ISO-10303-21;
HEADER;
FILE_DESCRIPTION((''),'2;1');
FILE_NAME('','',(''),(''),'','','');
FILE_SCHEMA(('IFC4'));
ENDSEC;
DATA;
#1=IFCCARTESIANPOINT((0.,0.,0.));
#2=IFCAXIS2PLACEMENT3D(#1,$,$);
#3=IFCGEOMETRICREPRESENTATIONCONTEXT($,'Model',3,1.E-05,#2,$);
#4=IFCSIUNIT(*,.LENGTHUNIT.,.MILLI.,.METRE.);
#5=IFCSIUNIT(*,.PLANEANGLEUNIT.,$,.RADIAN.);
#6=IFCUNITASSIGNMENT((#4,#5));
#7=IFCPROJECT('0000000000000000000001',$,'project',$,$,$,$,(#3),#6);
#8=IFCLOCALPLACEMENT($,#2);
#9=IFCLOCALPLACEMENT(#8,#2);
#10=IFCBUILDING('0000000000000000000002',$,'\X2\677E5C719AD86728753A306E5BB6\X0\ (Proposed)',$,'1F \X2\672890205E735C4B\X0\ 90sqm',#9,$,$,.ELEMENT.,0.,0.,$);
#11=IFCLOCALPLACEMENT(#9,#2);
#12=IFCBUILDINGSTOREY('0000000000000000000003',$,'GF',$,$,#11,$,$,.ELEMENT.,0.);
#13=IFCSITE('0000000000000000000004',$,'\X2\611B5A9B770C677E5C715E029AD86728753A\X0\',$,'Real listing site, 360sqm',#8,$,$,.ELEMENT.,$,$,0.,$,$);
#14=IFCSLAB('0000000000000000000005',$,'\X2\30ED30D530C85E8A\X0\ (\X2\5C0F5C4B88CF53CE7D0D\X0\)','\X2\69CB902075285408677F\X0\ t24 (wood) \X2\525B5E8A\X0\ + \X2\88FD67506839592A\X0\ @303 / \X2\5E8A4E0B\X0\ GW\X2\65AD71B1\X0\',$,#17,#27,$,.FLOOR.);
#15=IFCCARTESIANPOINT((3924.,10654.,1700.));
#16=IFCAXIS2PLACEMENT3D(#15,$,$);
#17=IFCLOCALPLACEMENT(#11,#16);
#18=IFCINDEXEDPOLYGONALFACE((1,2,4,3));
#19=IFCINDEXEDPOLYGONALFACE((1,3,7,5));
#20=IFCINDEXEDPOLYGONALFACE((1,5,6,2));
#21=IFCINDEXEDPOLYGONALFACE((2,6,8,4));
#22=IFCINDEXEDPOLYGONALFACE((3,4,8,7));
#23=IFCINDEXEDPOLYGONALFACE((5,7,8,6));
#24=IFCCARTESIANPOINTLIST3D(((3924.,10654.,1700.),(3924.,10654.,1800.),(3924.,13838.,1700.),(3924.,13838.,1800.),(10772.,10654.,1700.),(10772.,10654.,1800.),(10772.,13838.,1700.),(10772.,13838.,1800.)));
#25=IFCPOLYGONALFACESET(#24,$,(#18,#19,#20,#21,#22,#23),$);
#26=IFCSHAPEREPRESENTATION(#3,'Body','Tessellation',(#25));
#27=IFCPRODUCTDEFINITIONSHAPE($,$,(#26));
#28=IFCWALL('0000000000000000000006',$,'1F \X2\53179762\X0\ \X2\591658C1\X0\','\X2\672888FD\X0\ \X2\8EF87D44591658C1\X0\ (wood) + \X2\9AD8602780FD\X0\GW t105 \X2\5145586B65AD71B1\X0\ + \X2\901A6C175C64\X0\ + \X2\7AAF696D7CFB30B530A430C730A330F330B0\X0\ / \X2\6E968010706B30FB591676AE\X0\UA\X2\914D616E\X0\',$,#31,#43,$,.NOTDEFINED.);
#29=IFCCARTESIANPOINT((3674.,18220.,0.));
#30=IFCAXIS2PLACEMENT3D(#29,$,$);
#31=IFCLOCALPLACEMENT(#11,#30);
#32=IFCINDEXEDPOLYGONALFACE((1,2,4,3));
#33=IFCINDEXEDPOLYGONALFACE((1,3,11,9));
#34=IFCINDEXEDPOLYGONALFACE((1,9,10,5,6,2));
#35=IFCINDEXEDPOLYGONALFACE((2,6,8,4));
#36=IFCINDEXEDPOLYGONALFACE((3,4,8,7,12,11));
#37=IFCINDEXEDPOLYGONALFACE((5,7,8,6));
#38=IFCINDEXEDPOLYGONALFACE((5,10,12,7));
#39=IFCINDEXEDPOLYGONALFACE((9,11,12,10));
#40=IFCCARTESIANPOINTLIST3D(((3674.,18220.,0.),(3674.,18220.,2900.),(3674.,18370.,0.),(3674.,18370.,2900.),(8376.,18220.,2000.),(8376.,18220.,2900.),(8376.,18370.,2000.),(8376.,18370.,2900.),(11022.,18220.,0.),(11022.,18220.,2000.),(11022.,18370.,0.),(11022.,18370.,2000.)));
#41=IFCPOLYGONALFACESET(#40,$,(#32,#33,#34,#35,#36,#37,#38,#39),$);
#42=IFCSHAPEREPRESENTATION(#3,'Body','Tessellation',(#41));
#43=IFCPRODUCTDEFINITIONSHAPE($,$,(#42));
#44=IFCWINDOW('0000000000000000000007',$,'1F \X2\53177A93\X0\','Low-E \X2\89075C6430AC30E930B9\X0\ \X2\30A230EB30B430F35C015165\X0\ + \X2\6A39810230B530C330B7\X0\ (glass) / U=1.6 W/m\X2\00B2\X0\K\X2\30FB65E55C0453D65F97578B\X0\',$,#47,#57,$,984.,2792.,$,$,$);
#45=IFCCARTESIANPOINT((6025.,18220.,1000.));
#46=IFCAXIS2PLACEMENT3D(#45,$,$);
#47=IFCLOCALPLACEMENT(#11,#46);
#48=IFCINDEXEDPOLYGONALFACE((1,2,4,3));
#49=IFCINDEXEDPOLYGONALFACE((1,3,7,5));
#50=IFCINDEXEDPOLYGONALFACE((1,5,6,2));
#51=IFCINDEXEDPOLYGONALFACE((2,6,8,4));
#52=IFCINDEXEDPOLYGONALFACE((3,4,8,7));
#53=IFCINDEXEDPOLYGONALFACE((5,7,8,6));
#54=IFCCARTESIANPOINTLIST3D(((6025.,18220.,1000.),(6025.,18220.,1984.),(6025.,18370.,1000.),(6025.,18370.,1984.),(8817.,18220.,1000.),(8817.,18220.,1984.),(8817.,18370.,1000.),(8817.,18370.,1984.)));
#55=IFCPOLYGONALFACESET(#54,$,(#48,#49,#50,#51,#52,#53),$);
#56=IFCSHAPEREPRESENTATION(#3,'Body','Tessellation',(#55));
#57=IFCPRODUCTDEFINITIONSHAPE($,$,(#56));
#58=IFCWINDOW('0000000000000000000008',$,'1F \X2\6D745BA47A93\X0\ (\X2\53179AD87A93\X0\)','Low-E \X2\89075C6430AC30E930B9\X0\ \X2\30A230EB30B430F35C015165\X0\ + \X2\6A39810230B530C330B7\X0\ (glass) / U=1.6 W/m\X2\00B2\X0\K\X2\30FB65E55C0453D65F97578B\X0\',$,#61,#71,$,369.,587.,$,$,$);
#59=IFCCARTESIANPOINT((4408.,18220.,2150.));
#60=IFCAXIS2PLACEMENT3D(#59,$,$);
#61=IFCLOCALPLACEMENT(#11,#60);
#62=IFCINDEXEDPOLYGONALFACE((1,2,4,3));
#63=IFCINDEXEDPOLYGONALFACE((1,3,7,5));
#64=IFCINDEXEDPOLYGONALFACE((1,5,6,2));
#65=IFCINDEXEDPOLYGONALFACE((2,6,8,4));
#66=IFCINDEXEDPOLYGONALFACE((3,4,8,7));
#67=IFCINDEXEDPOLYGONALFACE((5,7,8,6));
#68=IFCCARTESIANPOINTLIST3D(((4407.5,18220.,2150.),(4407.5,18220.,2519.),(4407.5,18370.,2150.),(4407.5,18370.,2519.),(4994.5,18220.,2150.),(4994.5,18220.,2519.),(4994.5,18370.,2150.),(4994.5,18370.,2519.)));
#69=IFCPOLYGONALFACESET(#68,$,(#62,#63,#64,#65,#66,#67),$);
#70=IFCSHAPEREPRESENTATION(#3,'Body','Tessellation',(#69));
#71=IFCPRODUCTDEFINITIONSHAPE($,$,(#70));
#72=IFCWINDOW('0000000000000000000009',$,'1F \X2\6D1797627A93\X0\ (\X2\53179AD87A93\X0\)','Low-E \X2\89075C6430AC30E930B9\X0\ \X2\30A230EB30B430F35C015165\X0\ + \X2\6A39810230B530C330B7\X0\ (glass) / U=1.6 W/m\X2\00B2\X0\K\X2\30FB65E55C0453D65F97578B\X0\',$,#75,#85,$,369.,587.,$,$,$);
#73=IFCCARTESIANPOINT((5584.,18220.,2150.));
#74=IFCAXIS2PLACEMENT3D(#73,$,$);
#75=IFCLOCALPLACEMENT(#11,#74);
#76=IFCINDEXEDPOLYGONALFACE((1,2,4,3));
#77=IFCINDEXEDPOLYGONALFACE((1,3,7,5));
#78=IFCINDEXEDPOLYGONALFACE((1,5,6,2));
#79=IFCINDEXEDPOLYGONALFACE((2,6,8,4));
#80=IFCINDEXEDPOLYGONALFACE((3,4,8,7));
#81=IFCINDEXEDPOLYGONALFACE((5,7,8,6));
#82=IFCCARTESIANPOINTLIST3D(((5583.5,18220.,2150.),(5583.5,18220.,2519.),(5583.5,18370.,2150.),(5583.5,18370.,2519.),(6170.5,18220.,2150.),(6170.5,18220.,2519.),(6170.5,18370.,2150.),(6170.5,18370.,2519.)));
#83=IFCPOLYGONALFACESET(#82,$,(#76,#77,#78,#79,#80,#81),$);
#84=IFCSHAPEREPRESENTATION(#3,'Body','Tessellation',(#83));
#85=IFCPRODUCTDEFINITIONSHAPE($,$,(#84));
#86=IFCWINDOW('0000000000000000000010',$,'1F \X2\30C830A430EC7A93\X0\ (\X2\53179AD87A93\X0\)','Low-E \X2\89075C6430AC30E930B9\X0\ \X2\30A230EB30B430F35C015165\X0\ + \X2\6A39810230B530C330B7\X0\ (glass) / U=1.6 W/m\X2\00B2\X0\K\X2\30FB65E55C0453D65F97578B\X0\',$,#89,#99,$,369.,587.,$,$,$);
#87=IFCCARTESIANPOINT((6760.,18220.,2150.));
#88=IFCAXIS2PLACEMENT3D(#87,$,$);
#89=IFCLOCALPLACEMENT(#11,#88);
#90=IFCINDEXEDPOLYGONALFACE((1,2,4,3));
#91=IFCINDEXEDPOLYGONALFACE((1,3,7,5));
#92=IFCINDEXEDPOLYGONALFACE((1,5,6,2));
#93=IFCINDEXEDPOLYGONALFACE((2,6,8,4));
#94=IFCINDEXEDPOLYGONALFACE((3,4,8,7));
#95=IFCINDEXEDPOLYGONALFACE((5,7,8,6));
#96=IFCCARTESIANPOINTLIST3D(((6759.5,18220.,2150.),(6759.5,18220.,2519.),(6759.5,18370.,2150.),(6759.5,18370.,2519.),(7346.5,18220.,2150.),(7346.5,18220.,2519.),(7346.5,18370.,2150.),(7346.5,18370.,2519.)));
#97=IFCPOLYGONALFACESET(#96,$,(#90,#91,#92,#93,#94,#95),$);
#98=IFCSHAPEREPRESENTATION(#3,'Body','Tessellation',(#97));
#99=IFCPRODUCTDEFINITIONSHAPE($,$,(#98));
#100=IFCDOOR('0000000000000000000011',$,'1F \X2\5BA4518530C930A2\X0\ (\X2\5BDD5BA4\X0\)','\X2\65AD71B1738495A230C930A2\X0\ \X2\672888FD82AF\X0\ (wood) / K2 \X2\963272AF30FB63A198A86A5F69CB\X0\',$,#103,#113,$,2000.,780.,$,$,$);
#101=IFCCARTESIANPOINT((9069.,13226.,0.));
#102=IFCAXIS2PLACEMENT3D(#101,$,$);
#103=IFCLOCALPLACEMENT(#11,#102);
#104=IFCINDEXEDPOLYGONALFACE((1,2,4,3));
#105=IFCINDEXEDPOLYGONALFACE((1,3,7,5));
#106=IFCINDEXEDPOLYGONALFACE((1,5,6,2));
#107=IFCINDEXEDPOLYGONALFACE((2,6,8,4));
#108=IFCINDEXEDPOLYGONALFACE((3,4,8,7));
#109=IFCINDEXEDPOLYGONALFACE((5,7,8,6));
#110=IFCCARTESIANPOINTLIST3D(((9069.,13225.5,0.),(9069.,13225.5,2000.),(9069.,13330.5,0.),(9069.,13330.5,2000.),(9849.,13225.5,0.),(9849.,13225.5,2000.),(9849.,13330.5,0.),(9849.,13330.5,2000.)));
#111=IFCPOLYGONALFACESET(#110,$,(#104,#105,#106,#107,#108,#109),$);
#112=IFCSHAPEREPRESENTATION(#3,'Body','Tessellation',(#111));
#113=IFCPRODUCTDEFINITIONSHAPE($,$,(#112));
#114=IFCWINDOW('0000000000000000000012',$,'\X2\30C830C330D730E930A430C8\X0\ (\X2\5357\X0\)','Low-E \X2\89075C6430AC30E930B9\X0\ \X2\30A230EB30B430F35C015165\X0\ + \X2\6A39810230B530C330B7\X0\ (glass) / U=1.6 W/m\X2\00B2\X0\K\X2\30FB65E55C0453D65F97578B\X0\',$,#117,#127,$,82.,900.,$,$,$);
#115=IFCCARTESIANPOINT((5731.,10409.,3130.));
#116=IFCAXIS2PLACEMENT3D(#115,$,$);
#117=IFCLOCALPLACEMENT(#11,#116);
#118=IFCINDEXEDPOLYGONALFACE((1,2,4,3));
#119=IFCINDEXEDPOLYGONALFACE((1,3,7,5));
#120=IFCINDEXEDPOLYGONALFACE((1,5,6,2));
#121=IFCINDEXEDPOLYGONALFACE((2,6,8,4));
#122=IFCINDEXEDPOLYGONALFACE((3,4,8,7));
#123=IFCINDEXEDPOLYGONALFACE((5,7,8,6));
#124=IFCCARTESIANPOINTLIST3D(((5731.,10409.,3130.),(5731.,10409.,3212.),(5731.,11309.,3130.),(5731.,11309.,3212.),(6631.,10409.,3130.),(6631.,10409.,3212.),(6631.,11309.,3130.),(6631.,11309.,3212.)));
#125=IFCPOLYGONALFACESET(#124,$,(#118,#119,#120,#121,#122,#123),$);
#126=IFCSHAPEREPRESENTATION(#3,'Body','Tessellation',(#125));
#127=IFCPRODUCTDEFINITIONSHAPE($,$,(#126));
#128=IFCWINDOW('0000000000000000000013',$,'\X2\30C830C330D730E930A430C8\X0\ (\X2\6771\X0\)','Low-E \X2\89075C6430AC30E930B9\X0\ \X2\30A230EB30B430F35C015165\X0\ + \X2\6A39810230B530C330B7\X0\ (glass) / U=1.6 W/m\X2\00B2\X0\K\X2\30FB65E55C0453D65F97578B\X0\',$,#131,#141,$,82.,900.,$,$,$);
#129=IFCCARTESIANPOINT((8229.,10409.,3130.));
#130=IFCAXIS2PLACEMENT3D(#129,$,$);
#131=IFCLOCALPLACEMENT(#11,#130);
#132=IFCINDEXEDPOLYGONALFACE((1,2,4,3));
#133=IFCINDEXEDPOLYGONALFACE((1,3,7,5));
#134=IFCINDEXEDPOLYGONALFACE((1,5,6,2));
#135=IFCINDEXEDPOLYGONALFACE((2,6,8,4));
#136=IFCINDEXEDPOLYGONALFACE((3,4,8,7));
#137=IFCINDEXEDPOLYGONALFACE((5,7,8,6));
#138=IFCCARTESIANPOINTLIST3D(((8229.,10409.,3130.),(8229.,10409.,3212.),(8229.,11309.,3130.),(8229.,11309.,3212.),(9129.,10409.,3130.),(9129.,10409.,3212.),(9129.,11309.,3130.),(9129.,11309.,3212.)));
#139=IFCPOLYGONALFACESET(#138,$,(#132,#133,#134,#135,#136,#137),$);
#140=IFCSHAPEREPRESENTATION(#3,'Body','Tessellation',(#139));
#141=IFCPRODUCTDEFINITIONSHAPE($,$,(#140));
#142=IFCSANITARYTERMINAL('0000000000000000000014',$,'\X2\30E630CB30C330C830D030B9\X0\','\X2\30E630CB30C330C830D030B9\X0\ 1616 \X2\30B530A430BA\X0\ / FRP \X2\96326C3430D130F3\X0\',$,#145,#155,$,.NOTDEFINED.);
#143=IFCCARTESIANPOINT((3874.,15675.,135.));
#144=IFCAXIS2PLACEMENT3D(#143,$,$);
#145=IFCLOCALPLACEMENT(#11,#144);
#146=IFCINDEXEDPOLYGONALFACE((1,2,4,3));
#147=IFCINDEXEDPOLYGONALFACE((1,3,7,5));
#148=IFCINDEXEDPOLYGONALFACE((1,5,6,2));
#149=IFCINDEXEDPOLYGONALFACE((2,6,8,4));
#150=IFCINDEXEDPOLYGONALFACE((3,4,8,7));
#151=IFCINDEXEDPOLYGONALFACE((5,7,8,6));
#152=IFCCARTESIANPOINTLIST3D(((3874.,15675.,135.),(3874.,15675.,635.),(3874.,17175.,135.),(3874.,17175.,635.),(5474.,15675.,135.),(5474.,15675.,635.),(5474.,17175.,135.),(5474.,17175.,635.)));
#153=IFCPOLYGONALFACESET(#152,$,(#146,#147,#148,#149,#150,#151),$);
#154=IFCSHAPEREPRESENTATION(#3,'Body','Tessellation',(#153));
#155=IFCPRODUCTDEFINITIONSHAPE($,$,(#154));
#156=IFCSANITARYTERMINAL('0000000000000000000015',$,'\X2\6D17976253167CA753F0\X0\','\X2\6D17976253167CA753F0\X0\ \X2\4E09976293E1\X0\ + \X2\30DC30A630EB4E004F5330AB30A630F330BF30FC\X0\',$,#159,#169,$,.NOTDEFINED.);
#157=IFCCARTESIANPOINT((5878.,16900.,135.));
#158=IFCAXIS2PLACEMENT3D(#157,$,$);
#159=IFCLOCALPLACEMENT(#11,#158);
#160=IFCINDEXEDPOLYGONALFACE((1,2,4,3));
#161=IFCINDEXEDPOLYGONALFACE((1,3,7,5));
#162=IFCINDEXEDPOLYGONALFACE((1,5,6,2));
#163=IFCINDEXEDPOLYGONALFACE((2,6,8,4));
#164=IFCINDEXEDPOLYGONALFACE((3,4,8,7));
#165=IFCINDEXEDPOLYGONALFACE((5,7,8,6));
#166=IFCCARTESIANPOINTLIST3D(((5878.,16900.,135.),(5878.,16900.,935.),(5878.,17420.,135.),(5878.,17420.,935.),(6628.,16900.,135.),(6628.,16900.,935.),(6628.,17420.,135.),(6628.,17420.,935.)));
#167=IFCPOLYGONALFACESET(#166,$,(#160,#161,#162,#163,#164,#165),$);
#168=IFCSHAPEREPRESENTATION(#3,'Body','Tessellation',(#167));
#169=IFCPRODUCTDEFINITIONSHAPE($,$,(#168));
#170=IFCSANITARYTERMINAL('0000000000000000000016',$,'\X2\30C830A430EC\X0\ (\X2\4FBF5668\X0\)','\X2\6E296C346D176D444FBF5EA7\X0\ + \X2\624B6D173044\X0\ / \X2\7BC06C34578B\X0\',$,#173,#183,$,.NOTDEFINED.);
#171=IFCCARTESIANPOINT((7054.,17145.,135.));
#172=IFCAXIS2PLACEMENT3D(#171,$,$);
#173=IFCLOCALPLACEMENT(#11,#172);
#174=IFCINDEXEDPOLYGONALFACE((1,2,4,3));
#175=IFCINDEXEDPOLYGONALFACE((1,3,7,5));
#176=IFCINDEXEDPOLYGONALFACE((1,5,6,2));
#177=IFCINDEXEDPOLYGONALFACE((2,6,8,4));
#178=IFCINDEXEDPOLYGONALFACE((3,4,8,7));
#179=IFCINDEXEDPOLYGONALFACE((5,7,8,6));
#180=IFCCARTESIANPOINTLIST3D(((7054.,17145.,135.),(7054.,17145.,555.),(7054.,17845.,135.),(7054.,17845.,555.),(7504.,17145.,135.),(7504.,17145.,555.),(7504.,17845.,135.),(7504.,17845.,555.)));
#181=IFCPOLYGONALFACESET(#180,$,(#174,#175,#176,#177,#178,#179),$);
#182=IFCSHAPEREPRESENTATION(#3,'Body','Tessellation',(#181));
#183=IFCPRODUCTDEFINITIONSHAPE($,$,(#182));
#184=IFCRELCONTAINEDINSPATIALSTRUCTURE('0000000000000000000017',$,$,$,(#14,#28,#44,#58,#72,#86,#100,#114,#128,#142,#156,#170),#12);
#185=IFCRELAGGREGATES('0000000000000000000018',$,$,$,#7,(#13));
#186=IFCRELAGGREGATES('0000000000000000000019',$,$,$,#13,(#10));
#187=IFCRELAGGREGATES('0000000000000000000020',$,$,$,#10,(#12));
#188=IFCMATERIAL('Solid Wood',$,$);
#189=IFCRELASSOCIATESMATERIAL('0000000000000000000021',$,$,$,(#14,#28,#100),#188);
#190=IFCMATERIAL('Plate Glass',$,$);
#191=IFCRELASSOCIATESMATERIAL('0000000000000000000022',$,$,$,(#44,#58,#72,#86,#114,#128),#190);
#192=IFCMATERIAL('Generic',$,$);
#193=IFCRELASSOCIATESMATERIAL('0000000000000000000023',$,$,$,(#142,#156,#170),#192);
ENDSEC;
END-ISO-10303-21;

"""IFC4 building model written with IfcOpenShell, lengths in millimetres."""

from ifc_helpers import new_model, si_unit, frame, frame_2d, origin, place, context, project, spatial, rectangle, extrude, material, element, fill, save


model = new_model("IFC4")

# Units and contexts
model_context = context("Model", 3, precision=1e-05, world=origin())
ifc_project = project(units=[si_unit("LENGTHUNIT", "METRE", prefix="MILLI"), si_unit("PLANEANGLEUNIT", "RADIAN")], contexts=[model_context])

# Site, building, storey
site_placement = place(None, origin())
site = spatial("IfcSite", under=ifc_project, at=site_placement, Name="愛媛県松山市高木町", ObjectType="Real listing site, 360sqm", CompositionType="ELEMENT", RefElevation=0.0)
building_placement = place(site_placement, origin())
building = spatial("IfcBuilding", under=site, at=building_placement, Name="松山高木町の家 (Proposed)", ObjectType="1F 木造平屋 90sqm", CompositionType="ELEMENT", ElevationOfRefHeight=0.0, ElevationOfTerrain=0.0)
storey_placement = place(building_placement, origin())
storey = spatial("IfcBuildingStorey", under=building, at=storey_placement, Name="GF", CompositionType="ELEMENT", Elevation=0.0)

# Slab
ifc_material_1 = material(Name="Solid Wood")
slab_placement = place(storey_placement, frame((3924.0, 10654.0, 1700.0)))
element("IfcSlab", 1, at=slab_placement, inside=storey, material=ifc_material_1, Name="ロフト床 (小屋裏収納)", Description="構造用合板 t24 (wood) 剛床 + 製材根太 @303 / 床下 GW断熱", PredefinedType="FLOOR", context=model_context, shape_type="SweptSolid", body=[
    extrude(rectangle(XDim=6848.0, YDim=3184.0, at=frame_2d((3424.0, 1592.0))), frame((3924.0, 10654.0, 1700.0)), (0.0, 0.0, 1.0), 100.0),
])

# Wall, openings, windows
wall_1_placement = place(storey_placement, frame((3674.0, 18220.0, 0.0)))
wall_1 = element("IfcWall", 2, at=wall_1_placement, inside=storey, material=ifc_material_1, Name="1F 北面 外壁", Description="木製 軸組外壁 (wood) + 高性能GW t105 充填断熱 + 通気層 + 窯業系サイディング / 準耐火・外皮UA配慮", PredefinedType="NOTDEFINED", context=model_context, shape_type="SweptSolid", body=[
    extrude(rectangle(XDim=7348.0, YDim=150.0, at=frame_2d((3674.0, 75.0))), frame((3674.0, 18220.0, 0.0)), (0.0, 0.0, 1.0), 2900.0),
])
opening_1_placement = place(storey_placement, frame((6025.0, 18220.0, 1000.0)))
opening_1 = element("IfcOpeningElement", 3, at=opening_1_placement, cuts=wall_1, PredefinedType="NOTDEFINED", context=model_context, shape_type="SweptSolid", body=[
    extrude(rectangle(XDim=2792.0, YDim=150.0, at=frame_2d((1396.0, 75.0))), frame((6025.0, 18220.0, 1000.0)), (0.0, 0.0, 1.0), 984.0),
])
opening_2_placement = place(storey_placement, frame((4408.0, 18220.0, 2150.0)))
opening_2 = element("IfcOpeningElement", 4, at=opening_2_placement, cuts=wall_1, PredefinedType="NOTDEFINED", context=model_context, shape_type="SweptSolid", body=[
    extrude(rectangle(XDim=587.0, YDim=150.0, at=frame_2d((293.0, 75.0))), frame((4408.0, 18220.0, 2150.0)), (0.0, 0.0, 1.0), 369.0),
])
opening_3_placement = place(storey_placement, frame((5584.0, 18220.0, 2150.0)))
opening_3 = element("IfcOpeningElement", 5, at=opening_3_placement, cuts=wall_1, PredefinedType="NOTDEFINED", context=model_context, shape_type="SweptSolid", body=[
    extrude(rectangle(XDim=587.0, YDim=150.0, at=frame_2d((293.0, 75.0))), frame((5584.0, 18220.0, 2150.0)), (0.0, 0.0, 1.0), 369.0),
])
opening_4_placement = place(storey_placement, frame((6760.0, 18220.0, 2150.0)))
opening_4 = element("IfcOpeningElement", 6, at=opening_4_placement, cuts=wall_1, PredefinedType="NOTDEFINED", context=model_context, shape_type="SweptSolid", body=[
    extrude(rectangle(XDim=587.0, YDim=150.0, at=frame_2d((293.0, 75.0))), frame((6760.0, 18220.0, 2150.0)), (0.0, 0.0, 1.0), 369.0),
])
ifc_material_2 = material(Name="Plate Glass")
window_1_placement = place(storey_placement, frame((6025.0, 18220.0, 1000.0)))
window_1 = element("IfcWindow", 7, at=window_1_placement, inside=storey, material=ifc_material_2, Name="1F 北窓", Description="Low-E 複層ガラス アルゴン封入 + 樹脂サッシ (glass) / U=1.6 W/m²K・日射取得型", OverallHeight=984.0, OverallWidth=2792.0, context=model_context, shape_type="SweptSolid", body=[
    extrude(rectangle(XDim=2792.0, YDim=150.0, at=frame_2d((1396.0, 75.0))), frame((6025.0, 18220.0, 1000.0)), (0.0, 0.0, 1.0), 984.0),
])
fill(opening_1, window_1)
window_2_placement = place(storey_placement, frame((4408.0, 18220.0, 2150.0)))
window_2 = element("IfcWindow", 8, at=window_2_placement, inside=storey, material=ifc_material_2, Name="1F 浴室窓 (北高窓)", Description="Low-E 複層ガラス アルゴン封入 + 樹脂サッシ (glass) / U=1.6 W/m²K・日射取得型", OverallHeight=369.0, OverallWidth=587.0, context=model_context, shape_type="SweptSolid", body=[
    extrude(rectangle(XDim=587.0, YDim=150.0, at=frame_2d((293.0, 75.0))), frame((4408.0, 18220.0, 2150.0)), (0.0, 0.0, 1.0), 369.0),
])
fill(opening_2, window_2)
window_3_placement = place(storey_placement, frame((5584.0, 18220.0, 2150.0)))
window_3 = element("IfcWindow", 9, at=window_3_placement, inside=storey, material=ifc_material_2, Name="1F 洗面窓 (北高窓)", Description="Low-E 複層ガラス アルゴン封入 + 樹脂サッシ (glass) / U=1.6 W/m²K・日射取得型", OverallHeight=369.0, OverallWidth=587.0, context=model_context, shape_type="SweptSolid", body=[
    extrude(rectangle(XDim=587.0, YDim=150.0, at=frame_2d((293.0, 75.0))), frame((5584.0, 18220.0, 2150.0)), (0.0, 0.0, 1.0), 369.0),
])
fill(opening_3, window_3)
window_4_placement = place(storey_placement, frame((6760.0, 18220.0, 2150.0)))
window_4 = element("IfcWindow", 10, at=window_4_placement, inside=storey, material=ifc_material_2, Name="1F トイレ窓 (北高窓)", Description="Low-E 複層ガラス アルゴン封入 + 樹脂サッシ (glass) / U=1.6 W/m²K・日射取得型", OverallHeight=369.0, OverallWidth=587.0, context=model_context, shape_type="SweptSolid", body=[
    extrude(rectangle(XDim=587.0, YDim=150.0, at=frame_2d((293.0, 75.0))), frame((6760.0, 18220.0, 2150.0)), (0.0, 0.0, 1.0), 369.0),
])
fill(opening_4, window_4)

# Door
door_1_placement = place(storey_placement, frame((9069.0, 13226.0, 0.0)))
element("IfcDoor", 11, at=door_1_placement, inside=storey, material=ifc_material_1, Name="1F 室内ドア (寝室)", Description="断熱玄関ドア 木製芯 (wood) / K2 防犯・採風機構", OverallHeight=2000.0, OverallWidth=780.0, context=model_context, shape_type="SweptSolid", body=[
    extrude(rectangle(XDim=780.0, YDim=105.0, at=frame_2d((390.0, 52.0))), frame((9069.0, 13226.0, 0.0)), (0.0, 0.0, 1.0), 2000.0),
])

# Windows
window_5_placement = place(storey_placement, frame((5731.0, 10409.0, 3130.0)))
element("IfcWindow", 12, at=window_5_placement, inside=storey, material=ifc_material_2, Name="トップライト (南)", Description="Low-E 複層ガラス アルゴン封入 + 樹脂サッシ (glass) / U=1.6 W/m²K・日射取得型", OverallHeight=82.0, OverallWidth=900.0, context=model_context, shape_type="SweptSolid", body=[
    extrude(rectangle(XDim=900.0, YDim=900.0, at=frame_2d((450.0, 450.0))), frame((5731.0, 10409.0, 3130.0)), (0.0, 0.0, 1.0), 82.0),
])
window_6_placement = place(storey_placement, frame((8229.0, 10409.0, 3130.0)))
element("IfcWindow", 13, at=window_6_placement, inside=storey, material=ifc_material_2, Name="トップライト (東)", Description="Low-E 複層ガラス アルゴン封入 + 樹脂サッシ (glass) / U=1.6 W/m²K・日射取得型", OverallHeight=82.0, OverallWidth=900.0, context=model_context, shape_type="SweptSolid", body=[
    extrude(rectangle(XDim=900.0, YDim=900.0, at=frame_2d((450.0, 450.0))), frame((8229.0, 10409.0, 3130.0)), (0.0, 0.0, 1.0), 82.0),
])

# Sanitary terminals
ifc_material_3 = material(Name="Generic")
sanitary_terminal_1_placement = place(storey_placement, frame((3874.0, 15675.0, 135.0)))
element("IfcSanitaryTerminal", 14, at=sanitary_terminal_1_placement, inside=storey, material=ifc_material_3, Name="ユニットバス", Description="ユニットバス 1616 サイズ / FRP 防水パン", PredefinedType="NOTDEFINED", context=model_context, shape_type="SweptSolid", body=[
    extrude(rectangle(XDim=1600.0, YDim=1500.0, at=frame_2d((800.0, 750.0))), frame((3874.0, 15675.0, 135.0)), (0.0, 0.0, 1.0), 500.0),
])
sanitary_terminal_2_placement = place(storey_placement, frame((5878.0, 16900.0, 135.0)))
element("IfcSanitaryTerminal", 15, at=sanitary_terminal_2_placement, inside=storey, material=ifc_material_3, Name="洗面化粧台", Description="洗面化粧台 三面鏡 + ボウル一体カウンター", PredefinedType="NOTDEFINED", context=model_context, shape_type="SweptSolid", body=[
    extrude(rectangle(XDim=750.0, YDim=520.0, at=frame_2d((375.0, 260.0))), frame((5878.0, 16900.0, 135.0)), (0.0, 0.0, 1.0), 800.0),
])
sanitary_terminal_3_placement = place(storey_placement, frame((7054.0, 17145.0, 135.0)))
element("IfcSanitaryTerminal", 16, at=sanitary_terminal_3_placement, inside=storey, material=ifc_material_3, Name="トイレ (便器)", Description="温水洗浄便座 + 手洗い / 節水型", PredefinedType="NOTDEFINED", context=model_context, shape_type="SweptSolid", body=[
    extrude(rectangle(XDim=450.0, YDim=700.0, at=frame_2d((225.0, 350.0))), frame((7054.0, 17145.0, 135.0)), (0.0, 0.0, 1.0), 420.0),
])

save(model, "model.ifc")
